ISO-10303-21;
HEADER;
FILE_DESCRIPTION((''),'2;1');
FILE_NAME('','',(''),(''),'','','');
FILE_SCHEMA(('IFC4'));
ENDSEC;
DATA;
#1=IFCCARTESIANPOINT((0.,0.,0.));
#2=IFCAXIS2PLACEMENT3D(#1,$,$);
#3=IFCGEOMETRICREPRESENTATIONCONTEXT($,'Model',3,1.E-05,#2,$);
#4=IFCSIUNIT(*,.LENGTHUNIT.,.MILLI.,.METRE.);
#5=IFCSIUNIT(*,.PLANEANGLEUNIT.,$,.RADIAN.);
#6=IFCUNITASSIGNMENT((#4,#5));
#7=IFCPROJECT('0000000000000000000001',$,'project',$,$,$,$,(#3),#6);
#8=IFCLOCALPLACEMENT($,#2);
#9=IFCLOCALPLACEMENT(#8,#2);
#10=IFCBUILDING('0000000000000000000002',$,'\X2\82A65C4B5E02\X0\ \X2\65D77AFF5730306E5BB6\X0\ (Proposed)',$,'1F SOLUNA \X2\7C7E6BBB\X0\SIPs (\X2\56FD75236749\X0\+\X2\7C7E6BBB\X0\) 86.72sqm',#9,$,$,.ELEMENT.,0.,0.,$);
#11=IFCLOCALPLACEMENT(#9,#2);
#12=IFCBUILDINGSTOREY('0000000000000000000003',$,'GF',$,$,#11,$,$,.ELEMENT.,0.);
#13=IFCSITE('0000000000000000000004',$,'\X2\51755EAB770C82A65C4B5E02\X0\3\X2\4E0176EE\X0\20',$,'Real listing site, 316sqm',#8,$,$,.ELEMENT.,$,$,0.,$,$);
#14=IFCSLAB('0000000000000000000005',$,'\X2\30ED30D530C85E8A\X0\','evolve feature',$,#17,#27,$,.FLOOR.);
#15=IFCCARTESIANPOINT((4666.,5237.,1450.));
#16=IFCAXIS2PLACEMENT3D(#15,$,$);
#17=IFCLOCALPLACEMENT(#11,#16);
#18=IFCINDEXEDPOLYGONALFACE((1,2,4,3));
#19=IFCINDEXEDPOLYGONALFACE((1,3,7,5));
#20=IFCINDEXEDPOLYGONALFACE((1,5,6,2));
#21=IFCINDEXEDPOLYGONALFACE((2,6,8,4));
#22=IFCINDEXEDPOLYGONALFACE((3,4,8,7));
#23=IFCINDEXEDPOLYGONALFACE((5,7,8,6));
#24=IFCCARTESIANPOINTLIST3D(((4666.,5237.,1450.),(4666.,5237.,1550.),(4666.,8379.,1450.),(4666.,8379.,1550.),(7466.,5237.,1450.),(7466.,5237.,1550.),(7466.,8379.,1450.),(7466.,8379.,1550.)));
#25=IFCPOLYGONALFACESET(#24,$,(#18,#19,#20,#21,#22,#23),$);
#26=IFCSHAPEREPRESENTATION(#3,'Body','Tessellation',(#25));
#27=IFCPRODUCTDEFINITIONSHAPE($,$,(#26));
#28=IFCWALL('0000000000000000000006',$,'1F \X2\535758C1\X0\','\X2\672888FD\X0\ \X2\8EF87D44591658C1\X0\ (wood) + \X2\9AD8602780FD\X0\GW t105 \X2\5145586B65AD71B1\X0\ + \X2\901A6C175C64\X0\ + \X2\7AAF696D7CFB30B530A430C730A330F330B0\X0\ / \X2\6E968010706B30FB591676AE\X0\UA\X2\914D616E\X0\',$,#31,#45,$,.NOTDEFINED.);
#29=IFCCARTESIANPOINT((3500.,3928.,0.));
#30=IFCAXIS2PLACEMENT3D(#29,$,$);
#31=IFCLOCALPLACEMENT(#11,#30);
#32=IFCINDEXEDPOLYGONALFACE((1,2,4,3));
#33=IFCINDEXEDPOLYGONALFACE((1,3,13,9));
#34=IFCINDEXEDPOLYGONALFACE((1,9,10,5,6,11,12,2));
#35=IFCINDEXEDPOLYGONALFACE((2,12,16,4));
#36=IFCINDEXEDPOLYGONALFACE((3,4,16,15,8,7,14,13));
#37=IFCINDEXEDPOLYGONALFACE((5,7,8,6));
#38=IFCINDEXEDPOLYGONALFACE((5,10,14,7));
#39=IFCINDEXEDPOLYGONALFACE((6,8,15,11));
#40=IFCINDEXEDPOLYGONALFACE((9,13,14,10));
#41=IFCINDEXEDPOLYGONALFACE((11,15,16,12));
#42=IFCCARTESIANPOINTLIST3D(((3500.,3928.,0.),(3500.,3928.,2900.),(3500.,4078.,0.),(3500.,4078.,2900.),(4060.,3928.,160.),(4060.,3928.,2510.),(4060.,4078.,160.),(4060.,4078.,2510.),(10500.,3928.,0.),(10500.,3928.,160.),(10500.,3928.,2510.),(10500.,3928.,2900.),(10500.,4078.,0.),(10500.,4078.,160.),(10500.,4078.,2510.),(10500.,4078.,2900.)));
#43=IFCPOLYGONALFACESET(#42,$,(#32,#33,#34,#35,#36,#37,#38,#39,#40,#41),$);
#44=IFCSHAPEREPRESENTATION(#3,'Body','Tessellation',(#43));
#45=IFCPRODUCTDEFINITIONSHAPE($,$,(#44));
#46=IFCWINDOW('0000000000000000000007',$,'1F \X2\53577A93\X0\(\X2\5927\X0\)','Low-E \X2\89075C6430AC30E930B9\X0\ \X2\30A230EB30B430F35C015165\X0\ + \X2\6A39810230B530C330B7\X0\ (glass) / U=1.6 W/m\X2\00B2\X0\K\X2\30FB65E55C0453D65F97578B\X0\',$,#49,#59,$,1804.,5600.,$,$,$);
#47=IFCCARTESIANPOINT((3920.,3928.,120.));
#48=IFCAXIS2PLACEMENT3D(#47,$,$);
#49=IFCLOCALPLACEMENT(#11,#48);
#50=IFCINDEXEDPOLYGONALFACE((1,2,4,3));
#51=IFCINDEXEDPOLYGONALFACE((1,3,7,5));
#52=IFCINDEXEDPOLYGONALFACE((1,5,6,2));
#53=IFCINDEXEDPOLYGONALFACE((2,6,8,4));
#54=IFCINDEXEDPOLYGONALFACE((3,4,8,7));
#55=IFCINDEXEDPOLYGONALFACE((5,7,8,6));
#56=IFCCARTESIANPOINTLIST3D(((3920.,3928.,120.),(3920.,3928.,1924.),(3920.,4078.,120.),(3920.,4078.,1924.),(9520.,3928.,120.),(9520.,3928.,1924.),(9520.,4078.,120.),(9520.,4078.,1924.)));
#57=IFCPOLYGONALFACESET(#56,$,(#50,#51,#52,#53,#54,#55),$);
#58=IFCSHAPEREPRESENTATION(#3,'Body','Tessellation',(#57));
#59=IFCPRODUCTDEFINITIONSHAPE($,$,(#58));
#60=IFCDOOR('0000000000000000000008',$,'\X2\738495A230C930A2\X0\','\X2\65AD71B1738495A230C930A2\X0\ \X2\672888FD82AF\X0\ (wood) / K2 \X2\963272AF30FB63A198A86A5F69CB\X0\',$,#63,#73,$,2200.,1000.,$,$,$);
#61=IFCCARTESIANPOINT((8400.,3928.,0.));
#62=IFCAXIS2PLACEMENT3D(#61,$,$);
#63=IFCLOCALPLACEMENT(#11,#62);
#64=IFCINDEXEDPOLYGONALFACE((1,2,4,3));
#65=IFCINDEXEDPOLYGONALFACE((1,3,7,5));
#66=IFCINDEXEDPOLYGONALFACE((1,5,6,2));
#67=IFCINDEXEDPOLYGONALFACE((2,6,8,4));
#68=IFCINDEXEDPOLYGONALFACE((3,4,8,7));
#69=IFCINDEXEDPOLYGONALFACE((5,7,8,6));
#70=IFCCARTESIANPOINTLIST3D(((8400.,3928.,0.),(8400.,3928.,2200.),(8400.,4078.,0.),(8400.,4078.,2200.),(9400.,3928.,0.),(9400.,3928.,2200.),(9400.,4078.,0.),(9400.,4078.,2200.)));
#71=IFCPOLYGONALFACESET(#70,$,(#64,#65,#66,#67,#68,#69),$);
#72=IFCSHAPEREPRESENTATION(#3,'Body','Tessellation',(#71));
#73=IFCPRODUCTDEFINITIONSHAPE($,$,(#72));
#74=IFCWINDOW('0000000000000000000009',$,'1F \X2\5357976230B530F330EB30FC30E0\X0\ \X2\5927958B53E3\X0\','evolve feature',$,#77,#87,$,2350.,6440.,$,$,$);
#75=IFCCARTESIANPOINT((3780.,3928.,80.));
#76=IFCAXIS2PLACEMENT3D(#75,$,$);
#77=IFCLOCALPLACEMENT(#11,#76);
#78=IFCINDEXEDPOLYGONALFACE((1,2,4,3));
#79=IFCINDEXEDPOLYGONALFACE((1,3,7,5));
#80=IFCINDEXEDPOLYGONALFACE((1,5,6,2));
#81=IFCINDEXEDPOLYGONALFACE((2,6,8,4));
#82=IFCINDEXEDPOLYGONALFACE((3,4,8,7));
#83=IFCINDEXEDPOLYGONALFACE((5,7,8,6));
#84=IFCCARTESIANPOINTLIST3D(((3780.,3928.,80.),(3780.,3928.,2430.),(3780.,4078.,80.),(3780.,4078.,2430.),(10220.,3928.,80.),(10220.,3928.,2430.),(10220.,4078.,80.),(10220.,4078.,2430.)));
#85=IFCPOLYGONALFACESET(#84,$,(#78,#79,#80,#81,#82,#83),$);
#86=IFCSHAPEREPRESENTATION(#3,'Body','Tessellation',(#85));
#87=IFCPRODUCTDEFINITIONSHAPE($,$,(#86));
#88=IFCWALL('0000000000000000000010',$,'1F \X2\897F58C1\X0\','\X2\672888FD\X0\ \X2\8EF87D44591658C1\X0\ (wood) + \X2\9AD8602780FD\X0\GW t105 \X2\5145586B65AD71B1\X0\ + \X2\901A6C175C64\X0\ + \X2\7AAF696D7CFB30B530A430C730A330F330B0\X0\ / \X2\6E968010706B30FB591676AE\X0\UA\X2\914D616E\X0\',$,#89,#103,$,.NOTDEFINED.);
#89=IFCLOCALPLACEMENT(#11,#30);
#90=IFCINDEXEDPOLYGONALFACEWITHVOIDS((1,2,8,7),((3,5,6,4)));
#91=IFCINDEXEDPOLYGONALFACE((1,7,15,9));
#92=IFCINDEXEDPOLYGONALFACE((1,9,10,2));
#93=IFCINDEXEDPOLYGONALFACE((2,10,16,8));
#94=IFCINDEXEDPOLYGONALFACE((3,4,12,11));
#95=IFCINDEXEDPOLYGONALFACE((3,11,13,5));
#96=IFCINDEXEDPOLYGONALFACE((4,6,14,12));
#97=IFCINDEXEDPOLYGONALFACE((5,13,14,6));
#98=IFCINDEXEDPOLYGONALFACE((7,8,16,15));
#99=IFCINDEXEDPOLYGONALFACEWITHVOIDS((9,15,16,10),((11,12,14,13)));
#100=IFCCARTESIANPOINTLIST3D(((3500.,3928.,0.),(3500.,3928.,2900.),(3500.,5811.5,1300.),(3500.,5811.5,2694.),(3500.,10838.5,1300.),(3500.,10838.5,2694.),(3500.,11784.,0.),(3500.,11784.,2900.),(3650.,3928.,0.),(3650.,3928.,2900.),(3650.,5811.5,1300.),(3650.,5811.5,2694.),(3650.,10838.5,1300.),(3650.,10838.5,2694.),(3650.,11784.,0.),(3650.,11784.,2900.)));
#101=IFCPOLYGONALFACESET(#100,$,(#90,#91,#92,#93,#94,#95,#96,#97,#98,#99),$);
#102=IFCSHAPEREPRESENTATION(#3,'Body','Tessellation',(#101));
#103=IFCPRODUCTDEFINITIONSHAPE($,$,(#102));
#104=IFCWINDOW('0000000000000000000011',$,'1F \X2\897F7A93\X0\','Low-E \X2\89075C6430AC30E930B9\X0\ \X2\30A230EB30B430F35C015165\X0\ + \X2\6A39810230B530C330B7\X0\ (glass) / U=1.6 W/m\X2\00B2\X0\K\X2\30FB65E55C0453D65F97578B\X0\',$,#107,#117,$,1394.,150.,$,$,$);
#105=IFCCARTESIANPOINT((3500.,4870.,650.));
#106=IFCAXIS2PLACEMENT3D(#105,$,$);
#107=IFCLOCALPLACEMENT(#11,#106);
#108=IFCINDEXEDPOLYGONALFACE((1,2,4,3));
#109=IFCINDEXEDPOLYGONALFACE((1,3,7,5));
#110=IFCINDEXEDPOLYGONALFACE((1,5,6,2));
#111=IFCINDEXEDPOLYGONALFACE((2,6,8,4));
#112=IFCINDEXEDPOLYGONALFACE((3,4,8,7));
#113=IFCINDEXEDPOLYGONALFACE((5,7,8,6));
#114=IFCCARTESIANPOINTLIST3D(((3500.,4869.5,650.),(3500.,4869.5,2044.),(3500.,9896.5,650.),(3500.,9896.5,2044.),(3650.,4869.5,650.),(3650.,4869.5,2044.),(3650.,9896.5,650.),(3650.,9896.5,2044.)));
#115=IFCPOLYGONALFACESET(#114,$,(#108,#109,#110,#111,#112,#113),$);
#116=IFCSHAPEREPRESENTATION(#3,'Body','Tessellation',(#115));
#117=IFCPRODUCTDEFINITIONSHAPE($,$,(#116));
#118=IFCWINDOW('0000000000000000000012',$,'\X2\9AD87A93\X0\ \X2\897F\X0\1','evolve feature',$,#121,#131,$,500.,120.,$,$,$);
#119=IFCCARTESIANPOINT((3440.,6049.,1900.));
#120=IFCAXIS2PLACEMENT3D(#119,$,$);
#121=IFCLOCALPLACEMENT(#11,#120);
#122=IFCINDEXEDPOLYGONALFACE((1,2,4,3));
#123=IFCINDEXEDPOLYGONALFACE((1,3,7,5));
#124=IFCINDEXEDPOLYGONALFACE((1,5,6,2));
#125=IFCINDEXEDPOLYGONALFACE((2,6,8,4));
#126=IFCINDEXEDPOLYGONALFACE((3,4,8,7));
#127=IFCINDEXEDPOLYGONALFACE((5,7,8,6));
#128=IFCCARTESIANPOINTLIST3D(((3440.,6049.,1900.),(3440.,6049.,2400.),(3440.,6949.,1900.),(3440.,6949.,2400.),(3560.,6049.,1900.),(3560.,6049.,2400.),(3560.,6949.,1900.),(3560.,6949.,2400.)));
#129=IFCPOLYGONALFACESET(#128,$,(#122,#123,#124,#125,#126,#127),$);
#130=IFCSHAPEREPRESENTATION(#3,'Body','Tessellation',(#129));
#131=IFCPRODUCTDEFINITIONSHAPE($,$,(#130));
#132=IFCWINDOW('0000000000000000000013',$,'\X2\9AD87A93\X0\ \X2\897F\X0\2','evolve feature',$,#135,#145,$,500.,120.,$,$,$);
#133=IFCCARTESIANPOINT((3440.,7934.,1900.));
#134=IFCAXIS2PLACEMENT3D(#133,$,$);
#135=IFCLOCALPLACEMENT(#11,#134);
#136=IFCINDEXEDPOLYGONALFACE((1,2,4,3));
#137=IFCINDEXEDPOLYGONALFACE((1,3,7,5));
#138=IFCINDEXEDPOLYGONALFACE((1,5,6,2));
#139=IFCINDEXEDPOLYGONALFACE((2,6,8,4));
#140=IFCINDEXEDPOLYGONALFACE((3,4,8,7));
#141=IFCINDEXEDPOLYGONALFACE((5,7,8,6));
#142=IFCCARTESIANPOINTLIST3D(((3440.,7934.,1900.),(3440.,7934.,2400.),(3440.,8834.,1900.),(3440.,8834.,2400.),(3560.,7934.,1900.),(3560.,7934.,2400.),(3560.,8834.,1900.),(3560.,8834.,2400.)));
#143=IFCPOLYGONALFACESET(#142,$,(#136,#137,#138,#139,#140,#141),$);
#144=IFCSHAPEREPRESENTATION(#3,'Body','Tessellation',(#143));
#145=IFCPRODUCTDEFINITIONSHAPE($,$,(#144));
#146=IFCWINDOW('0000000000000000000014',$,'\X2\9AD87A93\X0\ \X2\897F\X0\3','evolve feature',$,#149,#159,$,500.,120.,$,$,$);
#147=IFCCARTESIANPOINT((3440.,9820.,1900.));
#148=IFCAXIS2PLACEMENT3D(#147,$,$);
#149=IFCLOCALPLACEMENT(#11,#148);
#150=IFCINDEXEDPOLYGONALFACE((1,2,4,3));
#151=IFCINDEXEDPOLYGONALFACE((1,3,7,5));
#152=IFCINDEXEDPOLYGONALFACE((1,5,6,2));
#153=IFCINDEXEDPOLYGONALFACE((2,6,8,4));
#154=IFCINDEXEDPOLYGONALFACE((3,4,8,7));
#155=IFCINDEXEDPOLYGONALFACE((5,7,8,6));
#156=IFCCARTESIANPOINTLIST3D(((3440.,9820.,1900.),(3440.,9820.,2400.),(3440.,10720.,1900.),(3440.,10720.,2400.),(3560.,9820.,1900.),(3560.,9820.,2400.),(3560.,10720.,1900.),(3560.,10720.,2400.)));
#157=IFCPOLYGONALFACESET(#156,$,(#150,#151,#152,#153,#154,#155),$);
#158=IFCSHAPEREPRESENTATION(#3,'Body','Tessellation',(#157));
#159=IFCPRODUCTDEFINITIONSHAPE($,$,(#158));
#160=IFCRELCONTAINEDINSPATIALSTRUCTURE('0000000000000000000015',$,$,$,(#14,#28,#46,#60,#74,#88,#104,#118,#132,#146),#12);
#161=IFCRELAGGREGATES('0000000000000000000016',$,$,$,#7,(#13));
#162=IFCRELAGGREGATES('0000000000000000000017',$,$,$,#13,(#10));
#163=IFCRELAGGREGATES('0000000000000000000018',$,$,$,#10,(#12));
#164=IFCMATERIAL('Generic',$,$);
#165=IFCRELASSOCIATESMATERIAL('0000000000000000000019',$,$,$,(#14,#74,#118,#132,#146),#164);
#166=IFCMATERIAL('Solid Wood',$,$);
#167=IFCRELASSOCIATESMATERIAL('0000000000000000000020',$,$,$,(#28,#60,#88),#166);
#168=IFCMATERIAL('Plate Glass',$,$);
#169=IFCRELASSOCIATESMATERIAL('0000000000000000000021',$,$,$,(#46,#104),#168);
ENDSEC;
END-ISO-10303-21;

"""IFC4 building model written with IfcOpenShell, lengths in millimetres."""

from ifc_helpers import new_model, si_unit, frame, frame_2d, origin, place, context, project, spatial, rectangle, extrude, material, element, fill, save


model = new_model("IFC4")

# Units and contexts
model_context = context("Model", 3, precision=1e-05, world=origin())
ifc_project = project(units=[si_unit("LENGTHUNIT", "METRE", prefix="MILLI"), si_unit("PLANEANGLEUNIT", "RADIAN")], contexts=[model_context])

# Site, building, storey
site_placement = place(None, origin())
site = spatial("IfcSite", under=ifc_project, at=site_placement, Name="兵庫県芦屋市3丁目20", ObjectType="Real listing site, 316sqm", CompositionType="ELEMENT", RefElevation=0.0)
building_placement = place(site_placement, origin())
building = spatial("IfcBuilding", under=site, at=building_placement, Name="芦屋市 旗竿地の家 (Proposed)", ObjectType="1F SOLUNA 籾殻SIPs (国産杉+籾殻) 86.72sqm", CompositionType="ELEMENT", ElevationOfRefHeight=0.0, ElevationOfTerrain=0.0)
storey_placement = place(building_placement, origin())
storey = spatial("IfcBuildingStorey", under=building, at=storey_placement, Name="GF", CompositionType="ELEMENT", Elevation=0.0)

# Slab
ifc_material_1 = material(Name="Solid Wood")
ifc_material_2 = material(Name="Generic")
slab_1_placement = place(storey_placement, frame((4666.0, 5237.0, 1450.0)))
element("IfcSlab", 1, at=slab_1_placement, inside=storey, material=ifc_material_2, Name="ロフト床", Description="evolve feature", PredefinedType="FLOOR", context=model_context, shape_type="SweptSolid", body=[
    extrude(rectangle(XDim=2800.0, YDim=3142.0, at=frame_2d((1400.0, 1571.0))), frame((4666.0, 5237.0, 1450.0)), (0.0, 0.0, 1.0), 100.0),
])

# Wall, openings, windows, door
wall_1_placement = place(storey_placement, frame((3500.0, 3928.0, 0.0)))
wall_1 = element("IfcWall", 2, at=wall_1_placement, inside=storey, material=ifc_material_1, Name="1F 南壁", Description="木製 軸組外壁 (wood) + 高性能GW t105 充填断熱 + 通気層 + 窯業系サイディング / 準耐火・外皮UA配慮", PredefinedType="NOTDEFINED", context=model_context, shape_type="SweptSolid", body=[
    extrude(rectangle(XDim=7000.0, YDim=150.0, at=frame_2d((3500.0, 75.0))), frame((3500.0, 3928.0, 0.0)), (0.0, 0.0, 1.0), 2900.0),
])
opening_1_placement = place(storey_placement, frame((3920.0, 3928.0, 120.0)))
opening_1 = element("IfcOpeningElement", 3, at=opening_1_placement, cuts=wall_1, PredefinedType="NOTDEFINED", context=model_context, shape_type="SweptSolid", body=[
    extrude(rectangle(XDim=5600.0, YDim=150.0, at=frame_2d((2800.0, 75.0))), frame((3920.0, 3928.0, 120.0)), (0.0, 0.0, 1.0), 1804.0),
])
opening_2_placement = place(storey_placement, frame((8400.0, 3928.0, 0.0)))
opening_2 = element("IfcOpeningElement", 4, at=opening_2_placement, cuts=wall_1, PredefinedType="NOTDEFINED", context=model_context, shape_type="SweptSolid", body=[
    extrude(rectangle(XDim=1000.0, YDim=150.0, at=frame_2d((500.0, 75.0))), frame((8400.0, 3928.0, 0.0)), (0.0, 0.0, 1.0), 2200.0),
])
opening_3_placement = place(storey_placement, frame((3780.0, 3928.0, 80.0)))
opening_3 = element("IfcOpeningElement", 5, at=opening_3_placement, cuts=wall_1, PredefinedType="NOTDEFINED", context=model_context, shape_type="SweptSolid", body=[
    extrude(rectangle(XDim=6440.0, YDim=150.0, at=frame_2d((3220.0, 75.0))), frame((3780.0, 3928.0, 80.0)), (0.0, 0.0, 1.0), 2350.0),
])
ifc_material_3 = material(Name="Plate Glass")
window_1_placement = place(storey_placement, frame((3920.0, 3928.0, 120.0)))
window_1 = element("IfcWindow", 6, at=window_1_placement, inside=storey, material=ifc_material_3, Name="1F 南窓(大)", Description="Low-E 複層ガラス アルゴン封入 + 樹脂サッシ (glass) / U=1.6 W/m²K・日射取得型", OverallHeight=1804.0, OverallWidth=5600.0, context=model_context, shape_type="SweptSolid", body=[
    extrude(rectangle(XDim=5600.0, YDim=150.0, at=frame_2d((2800.0, 75.0))), frame((3920.0, 3928.0, 120.0)), (0.0, 0.0, 1.0), 1804.0),
])
fill(opening_1, window_1)
door_placement = place(storey_placement, frame((8400.0, 3928.0, 0.0)))
door = element("IfcDoor", 7, at=door_placement, inside=storey, material=ifc_material_1, Name="玄関ドア", Description="断熱玄関ドア 木製芯 (wood) / K2 防犯・採風機構", OverallHeight=2200.0, OverallWidth=1000.0, context=model_context, shape_type="SweptSolid", body=[
    extrude(rectangle(XDim=1000.0, YDim=150.0, at=frame_2d((500.0, 75.0))), frame((8400.0, 3928.0, 0.0)), (0.0, 0.0, 1.0), 2200.0),
])
fill(opening_2, door)
window_2_placement = place(storey_placement, frame((3780.0, 3928.0, 80.0)))
window_2 = element("IfcWindow", 8, at=window_2_placement, inside=storey, material=ifc_material_2, Name="1F 南面サンルーム 大開口", Description="evolve feature", OverallHeight=2350.0, OverallWidth=6440.0, context=model_context, shape_type="SweptSolid", body=[
    extrude(rectangle(XDim=6440.0, YDim=150.0, at=frame_2d((3220.0, 75.0))), frame((3780.0, 3928.0, 80.0)), (0.0, 0.0, 1.0), 2350.0),
])
fill(opening_3, window_2)

# Wall, openings, windows
wall_2_placement = place(storey_placement, frame((3500.0, 3928.0, 0.0)))
wall_2 = element("IfcWall", 9, at=wall_2_placement, inside=storey, material=ifc_material_1, Name="1F 西壁", Description="木製 軸組外壁 (wood) + 高性能GW t105 充填断熱 + 通気層 + 窯業系サイディング / 準耐火・外皮UA配慮", PredefinedType="NOTDEFINED", context=model_context, shape_type="SweptSolid", body=[
    extrude(rectangle(XDim=150.0, YDim=7856.0, at=frame_2d((75.0, 3928.0))), frame((3500.0, 3928.0, 0.0)), (0.0, 0.0, 1.0), 2900.0),
])
opening_4_placement = place(storey_placement, frame((3500.0, 4870.0, 650.0)))
opening_4 = element("IfcOpeningElement", 10, at=opening_4_placement, cuts=wall_2, PredefinedType="NOTDEFINED", context=model_context, shape_type="SweptSolid", body=[
    extrude(rectangle(XDim=150.0, YDim=5027.0, at=frame_2d((75.0, 2513.0))), frame((3500.0, 4870.0, 650.0)), (0.0, 0.0, 1.0), 1394.0),
])
opening_5_placement = place(storey_placement, frame((3440.0, 6049.0, 1900.0)))
opening_5 = element("IfcOpeningElement", 11, at=opening_5_placement, cuts=wall_2, PredefinedType="NOTDEFINED", context=model_context, shape_type="SweptSolid", body=[
    extrude(rectangle(XDim=120.0, YDim=900.0, at=frame_2d((60.0, 450.0))), frame((3440.0, 6049.0, 1900.0)), (0.0, 0.0, 1.0), 500.0),
])
opening_6_placement = place(storey_placement, frame((3440.0, 7934.0, 1900.0)))
opening_6 = element("IfcOpeningElement", 12, at=opening_6_placement, cuts=wall_2, PredefinedType="NOTDEFINED", context=model_context, shape_type="SweptSolid", body=[
    extrude(rectangle(XDim=120.0, YDim=900.0, at=frame_2d((60.0, 450.0))), frame((3440.0, 7934.0, 1900.0)), (0.0, 0.0, 1.0), 500.0),
])
opening_7_placement = place(storey_placement, frame((3440.0, 9820.0, 1900.0)))
opening_7 = element("IfcOpeningElement", 13, at=opening_7_placement, cuts=wall_2, PredefinedType="NOTDEFINED", context=model_context, shape_type="SweptSolid", body=[
    extrude(rectangle(XDim=120.0, YDim=900.0, at=frame_2d((60.0, 450.0))), frame((3440.0, 9820.0, 1900.0)), (0.0, 0.0, 1.0), 500.0),
])
window_3_placement = place(storey_placement, frame((3500.0, 4870.0, 650.0)))
window_3 = element("IfcWindow", 14, at=window_3_placement, inside=storey, material=ifc_material_3, Name="1F 西窓", Description="Low-E 複層ガラス アルゴン封入 + 樹脂サッシ (glass) / U=1.6 W/m²K・日射取得型", OverallHeight=1394.0, OverallWidth=150.0, context=model_context, shape_type="SweptSolid", body=[
    extrude(rectangle(XDim=150.0, YDim=5027.0, at=frame_2d((75.0, 2513.0))), frame((3500.0, 4870.0, 650.0)), (0.0, 0.0, 1.0), 1394.0),
])
fill(opening_4, window_3)
window_4_placement = place(storey_placement, frame((3440.0, 6049.0, 1900.0)))
window_4 = element("IfcWindow", 15, at=window_4_placement, inside=storey, material=ifc_material_2, Name="高窓 西1", Description="evolve feature", OverallHeight=500.0, OverallWidth=120.0, context=model_context, shape_type="SweptSolid", body=[
    extrude(rectangle(XDim=120.0, YDim=900.0, at=frame_2d((60.0, 450.0))), frame((3440.0, 6049.0, 1900.0)), (0.0, 0.0, 1.0), 500.0),
])
fill(opening_5, window_4)
window_5_placement = place(storey_placement, frame((3440.0, 7934.0, 1900.0)))
window_5 = element("IfcWindow", 16, at=window_5_placement, inside=storey, material=ifc_material_2, Name="高窓 西2", Description="evolve feature", OverallHeight=500.0, OverallWidth=120.0, context=model_context, shape_type="SweptSolid", body=[
    extrude(rectangle(XDim=120.0, YDim=900.0, at=frame_2d((60.0, 450.0))), frame((3440.0, 7934.0, 1900.0)), (0.0, 0.0, 1.0), 500.0),
])
fill(opening_6, window_5)
window_6_placement = place(storey_placement, frame((3440.0, 9820.0, 1900.0)))
window_6 = element("IfcWindow", 17, at=window_6_placement, inside=storey, material=ifc_material_2, Name="高窓 西3", Description="evolve feature", OverallHeight=500.0, OverallWidth=120.0, context=model_context, shape_type="SweptSolid", body=[
    extrude(rectangle(XDim=120.0, YDim=900.0, at=frame_2d((60.0, 450.0))), frame((3440.0, 9820.0, 1900.0)), (0.0, 0.0, 1.0), 500.0),
])
fill(opening_7, window_6)

save(model, "model.ifc")
